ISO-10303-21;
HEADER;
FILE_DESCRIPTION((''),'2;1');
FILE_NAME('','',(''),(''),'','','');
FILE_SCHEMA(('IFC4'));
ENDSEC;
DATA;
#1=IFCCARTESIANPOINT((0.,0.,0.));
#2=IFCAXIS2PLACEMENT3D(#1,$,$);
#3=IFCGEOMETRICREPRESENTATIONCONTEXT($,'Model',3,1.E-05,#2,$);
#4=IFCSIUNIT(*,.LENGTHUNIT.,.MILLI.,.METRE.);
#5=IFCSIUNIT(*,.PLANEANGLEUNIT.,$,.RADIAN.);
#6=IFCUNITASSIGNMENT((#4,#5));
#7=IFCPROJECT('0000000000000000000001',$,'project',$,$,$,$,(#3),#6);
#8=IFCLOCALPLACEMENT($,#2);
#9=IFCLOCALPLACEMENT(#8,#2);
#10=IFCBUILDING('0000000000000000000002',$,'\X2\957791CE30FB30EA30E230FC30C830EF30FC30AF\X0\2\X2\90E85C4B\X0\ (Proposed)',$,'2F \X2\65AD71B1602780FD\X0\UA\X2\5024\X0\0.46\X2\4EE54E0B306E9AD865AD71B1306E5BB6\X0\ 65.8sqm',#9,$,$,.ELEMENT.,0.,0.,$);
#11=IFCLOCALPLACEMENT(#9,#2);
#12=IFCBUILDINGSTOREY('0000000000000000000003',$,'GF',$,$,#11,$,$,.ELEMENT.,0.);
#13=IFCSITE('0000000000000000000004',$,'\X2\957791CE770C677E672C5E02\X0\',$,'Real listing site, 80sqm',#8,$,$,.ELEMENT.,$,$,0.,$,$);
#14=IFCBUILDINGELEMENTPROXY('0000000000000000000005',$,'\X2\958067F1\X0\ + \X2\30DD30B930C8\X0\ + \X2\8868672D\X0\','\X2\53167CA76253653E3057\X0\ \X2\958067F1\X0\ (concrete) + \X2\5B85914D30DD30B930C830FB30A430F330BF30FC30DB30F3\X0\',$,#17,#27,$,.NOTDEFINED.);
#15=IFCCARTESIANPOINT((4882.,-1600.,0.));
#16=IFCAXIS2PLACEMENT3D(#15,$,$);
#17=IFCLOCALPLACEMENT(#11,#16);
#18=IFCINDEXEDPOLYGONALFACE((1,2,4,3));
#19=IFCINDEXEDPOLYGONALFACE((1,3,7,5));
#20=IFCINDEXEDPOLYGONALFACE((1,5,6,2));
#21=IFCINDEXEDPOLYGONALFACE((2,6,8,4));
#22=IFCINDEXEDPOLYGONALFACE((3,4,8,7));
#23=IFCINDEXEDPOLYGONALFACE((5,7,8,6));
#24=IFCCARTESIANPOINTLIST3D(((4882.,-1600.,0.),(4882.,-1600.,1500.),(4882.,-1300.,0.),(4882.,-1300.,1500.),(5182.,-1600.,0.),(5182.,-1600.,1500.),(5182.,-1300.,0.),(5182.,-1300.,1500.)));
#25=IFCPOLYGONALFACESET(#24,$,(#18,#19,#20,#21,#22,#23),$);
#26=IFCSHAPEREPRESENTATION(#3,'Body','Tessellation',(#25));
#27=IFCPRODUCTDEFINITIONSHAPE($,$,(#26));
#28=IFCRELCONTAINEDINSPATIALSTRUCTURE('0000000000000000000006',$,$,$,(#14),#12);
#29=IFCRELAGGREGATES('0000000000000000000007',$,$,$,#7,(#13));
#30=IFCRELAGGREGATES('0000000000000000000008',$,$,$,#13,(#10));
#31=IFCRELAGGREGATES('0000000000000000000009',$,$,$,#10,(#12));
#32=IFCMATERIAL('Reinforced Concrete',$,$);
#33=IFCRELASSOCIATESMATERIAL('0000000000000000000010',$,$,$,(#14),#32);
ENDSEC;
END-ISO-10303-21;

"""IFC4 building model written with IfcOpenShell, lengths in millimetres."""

from ifc_helpers import new_model, si_unit, frame, frame_2d, origin, place, context, project, spatial, rectangle, extrude, material, element, save


model = new_model("IFC4")

# Units and contexts
model_context = context("Model", 3, precision=1e-05, world=origin())
ifc_project = project(units=[si_unit("LENGTHUNIT", "METRE", prefix="MILLI"), si_unit("PLANEANGLEUNIT", "RADIAN")], contexts=[model_context])

# Site, building, storey
site_placement = place(None, origin())
site = spatial("IfcSite", under=ifc_project, at=site_placement, Name="長野県松本市", ObjectType="Real listing site, 80sqm", CompositionType="ELEMENT", RefElevation=0.0)
building_placement = place(site_placement, origin())
building = spatial("IfcBuilding", under=site, at=building_placement, Name="長野・リモートワーク2部屋 (Proposed)", ObjectType="2F 断熱性能UA値0.46以下の高断熱の家 65.8sqm", CompositionType="ELEMENT", ElevationOfRefHeight=0.0, ElevationOfTerrain=0.0)
storey_placement = place(building_placement, origin())
storey = spatial("IfcBuildingStorey", under=building, at=storey_placement, Name="GF", CompositionType="ELEMENT", Elevation=0.0)

# Shared definitions
ifc_material_1 = material(Name="Reinforced Concrete")

# Building element proxy
proxy_placement = place(storey_placement, frame((4882.0, -1600.0, 0.0)))
element("IfcBuildingElementProxy", 1, at=proxy_placement, inside=storey, material=ifc_material_1, Name="門柱 + ポスト + 表札", Description="化粧打放し 門柱 (concrete) + 宅配ポスト・インターホン", PredefinedType="NOTDEFINED", context=model_context, shape_type="SweptSolid", body=[
    extrude(rectangle(XDim=300.0, YDim=300.0, at=frame_2d((150.0, 150.0))), frame((4882.0, -1600.0, 0.0)), (0.0, 0.0, 1.0), 1500.0),
])

save(model, "model.ifc")
